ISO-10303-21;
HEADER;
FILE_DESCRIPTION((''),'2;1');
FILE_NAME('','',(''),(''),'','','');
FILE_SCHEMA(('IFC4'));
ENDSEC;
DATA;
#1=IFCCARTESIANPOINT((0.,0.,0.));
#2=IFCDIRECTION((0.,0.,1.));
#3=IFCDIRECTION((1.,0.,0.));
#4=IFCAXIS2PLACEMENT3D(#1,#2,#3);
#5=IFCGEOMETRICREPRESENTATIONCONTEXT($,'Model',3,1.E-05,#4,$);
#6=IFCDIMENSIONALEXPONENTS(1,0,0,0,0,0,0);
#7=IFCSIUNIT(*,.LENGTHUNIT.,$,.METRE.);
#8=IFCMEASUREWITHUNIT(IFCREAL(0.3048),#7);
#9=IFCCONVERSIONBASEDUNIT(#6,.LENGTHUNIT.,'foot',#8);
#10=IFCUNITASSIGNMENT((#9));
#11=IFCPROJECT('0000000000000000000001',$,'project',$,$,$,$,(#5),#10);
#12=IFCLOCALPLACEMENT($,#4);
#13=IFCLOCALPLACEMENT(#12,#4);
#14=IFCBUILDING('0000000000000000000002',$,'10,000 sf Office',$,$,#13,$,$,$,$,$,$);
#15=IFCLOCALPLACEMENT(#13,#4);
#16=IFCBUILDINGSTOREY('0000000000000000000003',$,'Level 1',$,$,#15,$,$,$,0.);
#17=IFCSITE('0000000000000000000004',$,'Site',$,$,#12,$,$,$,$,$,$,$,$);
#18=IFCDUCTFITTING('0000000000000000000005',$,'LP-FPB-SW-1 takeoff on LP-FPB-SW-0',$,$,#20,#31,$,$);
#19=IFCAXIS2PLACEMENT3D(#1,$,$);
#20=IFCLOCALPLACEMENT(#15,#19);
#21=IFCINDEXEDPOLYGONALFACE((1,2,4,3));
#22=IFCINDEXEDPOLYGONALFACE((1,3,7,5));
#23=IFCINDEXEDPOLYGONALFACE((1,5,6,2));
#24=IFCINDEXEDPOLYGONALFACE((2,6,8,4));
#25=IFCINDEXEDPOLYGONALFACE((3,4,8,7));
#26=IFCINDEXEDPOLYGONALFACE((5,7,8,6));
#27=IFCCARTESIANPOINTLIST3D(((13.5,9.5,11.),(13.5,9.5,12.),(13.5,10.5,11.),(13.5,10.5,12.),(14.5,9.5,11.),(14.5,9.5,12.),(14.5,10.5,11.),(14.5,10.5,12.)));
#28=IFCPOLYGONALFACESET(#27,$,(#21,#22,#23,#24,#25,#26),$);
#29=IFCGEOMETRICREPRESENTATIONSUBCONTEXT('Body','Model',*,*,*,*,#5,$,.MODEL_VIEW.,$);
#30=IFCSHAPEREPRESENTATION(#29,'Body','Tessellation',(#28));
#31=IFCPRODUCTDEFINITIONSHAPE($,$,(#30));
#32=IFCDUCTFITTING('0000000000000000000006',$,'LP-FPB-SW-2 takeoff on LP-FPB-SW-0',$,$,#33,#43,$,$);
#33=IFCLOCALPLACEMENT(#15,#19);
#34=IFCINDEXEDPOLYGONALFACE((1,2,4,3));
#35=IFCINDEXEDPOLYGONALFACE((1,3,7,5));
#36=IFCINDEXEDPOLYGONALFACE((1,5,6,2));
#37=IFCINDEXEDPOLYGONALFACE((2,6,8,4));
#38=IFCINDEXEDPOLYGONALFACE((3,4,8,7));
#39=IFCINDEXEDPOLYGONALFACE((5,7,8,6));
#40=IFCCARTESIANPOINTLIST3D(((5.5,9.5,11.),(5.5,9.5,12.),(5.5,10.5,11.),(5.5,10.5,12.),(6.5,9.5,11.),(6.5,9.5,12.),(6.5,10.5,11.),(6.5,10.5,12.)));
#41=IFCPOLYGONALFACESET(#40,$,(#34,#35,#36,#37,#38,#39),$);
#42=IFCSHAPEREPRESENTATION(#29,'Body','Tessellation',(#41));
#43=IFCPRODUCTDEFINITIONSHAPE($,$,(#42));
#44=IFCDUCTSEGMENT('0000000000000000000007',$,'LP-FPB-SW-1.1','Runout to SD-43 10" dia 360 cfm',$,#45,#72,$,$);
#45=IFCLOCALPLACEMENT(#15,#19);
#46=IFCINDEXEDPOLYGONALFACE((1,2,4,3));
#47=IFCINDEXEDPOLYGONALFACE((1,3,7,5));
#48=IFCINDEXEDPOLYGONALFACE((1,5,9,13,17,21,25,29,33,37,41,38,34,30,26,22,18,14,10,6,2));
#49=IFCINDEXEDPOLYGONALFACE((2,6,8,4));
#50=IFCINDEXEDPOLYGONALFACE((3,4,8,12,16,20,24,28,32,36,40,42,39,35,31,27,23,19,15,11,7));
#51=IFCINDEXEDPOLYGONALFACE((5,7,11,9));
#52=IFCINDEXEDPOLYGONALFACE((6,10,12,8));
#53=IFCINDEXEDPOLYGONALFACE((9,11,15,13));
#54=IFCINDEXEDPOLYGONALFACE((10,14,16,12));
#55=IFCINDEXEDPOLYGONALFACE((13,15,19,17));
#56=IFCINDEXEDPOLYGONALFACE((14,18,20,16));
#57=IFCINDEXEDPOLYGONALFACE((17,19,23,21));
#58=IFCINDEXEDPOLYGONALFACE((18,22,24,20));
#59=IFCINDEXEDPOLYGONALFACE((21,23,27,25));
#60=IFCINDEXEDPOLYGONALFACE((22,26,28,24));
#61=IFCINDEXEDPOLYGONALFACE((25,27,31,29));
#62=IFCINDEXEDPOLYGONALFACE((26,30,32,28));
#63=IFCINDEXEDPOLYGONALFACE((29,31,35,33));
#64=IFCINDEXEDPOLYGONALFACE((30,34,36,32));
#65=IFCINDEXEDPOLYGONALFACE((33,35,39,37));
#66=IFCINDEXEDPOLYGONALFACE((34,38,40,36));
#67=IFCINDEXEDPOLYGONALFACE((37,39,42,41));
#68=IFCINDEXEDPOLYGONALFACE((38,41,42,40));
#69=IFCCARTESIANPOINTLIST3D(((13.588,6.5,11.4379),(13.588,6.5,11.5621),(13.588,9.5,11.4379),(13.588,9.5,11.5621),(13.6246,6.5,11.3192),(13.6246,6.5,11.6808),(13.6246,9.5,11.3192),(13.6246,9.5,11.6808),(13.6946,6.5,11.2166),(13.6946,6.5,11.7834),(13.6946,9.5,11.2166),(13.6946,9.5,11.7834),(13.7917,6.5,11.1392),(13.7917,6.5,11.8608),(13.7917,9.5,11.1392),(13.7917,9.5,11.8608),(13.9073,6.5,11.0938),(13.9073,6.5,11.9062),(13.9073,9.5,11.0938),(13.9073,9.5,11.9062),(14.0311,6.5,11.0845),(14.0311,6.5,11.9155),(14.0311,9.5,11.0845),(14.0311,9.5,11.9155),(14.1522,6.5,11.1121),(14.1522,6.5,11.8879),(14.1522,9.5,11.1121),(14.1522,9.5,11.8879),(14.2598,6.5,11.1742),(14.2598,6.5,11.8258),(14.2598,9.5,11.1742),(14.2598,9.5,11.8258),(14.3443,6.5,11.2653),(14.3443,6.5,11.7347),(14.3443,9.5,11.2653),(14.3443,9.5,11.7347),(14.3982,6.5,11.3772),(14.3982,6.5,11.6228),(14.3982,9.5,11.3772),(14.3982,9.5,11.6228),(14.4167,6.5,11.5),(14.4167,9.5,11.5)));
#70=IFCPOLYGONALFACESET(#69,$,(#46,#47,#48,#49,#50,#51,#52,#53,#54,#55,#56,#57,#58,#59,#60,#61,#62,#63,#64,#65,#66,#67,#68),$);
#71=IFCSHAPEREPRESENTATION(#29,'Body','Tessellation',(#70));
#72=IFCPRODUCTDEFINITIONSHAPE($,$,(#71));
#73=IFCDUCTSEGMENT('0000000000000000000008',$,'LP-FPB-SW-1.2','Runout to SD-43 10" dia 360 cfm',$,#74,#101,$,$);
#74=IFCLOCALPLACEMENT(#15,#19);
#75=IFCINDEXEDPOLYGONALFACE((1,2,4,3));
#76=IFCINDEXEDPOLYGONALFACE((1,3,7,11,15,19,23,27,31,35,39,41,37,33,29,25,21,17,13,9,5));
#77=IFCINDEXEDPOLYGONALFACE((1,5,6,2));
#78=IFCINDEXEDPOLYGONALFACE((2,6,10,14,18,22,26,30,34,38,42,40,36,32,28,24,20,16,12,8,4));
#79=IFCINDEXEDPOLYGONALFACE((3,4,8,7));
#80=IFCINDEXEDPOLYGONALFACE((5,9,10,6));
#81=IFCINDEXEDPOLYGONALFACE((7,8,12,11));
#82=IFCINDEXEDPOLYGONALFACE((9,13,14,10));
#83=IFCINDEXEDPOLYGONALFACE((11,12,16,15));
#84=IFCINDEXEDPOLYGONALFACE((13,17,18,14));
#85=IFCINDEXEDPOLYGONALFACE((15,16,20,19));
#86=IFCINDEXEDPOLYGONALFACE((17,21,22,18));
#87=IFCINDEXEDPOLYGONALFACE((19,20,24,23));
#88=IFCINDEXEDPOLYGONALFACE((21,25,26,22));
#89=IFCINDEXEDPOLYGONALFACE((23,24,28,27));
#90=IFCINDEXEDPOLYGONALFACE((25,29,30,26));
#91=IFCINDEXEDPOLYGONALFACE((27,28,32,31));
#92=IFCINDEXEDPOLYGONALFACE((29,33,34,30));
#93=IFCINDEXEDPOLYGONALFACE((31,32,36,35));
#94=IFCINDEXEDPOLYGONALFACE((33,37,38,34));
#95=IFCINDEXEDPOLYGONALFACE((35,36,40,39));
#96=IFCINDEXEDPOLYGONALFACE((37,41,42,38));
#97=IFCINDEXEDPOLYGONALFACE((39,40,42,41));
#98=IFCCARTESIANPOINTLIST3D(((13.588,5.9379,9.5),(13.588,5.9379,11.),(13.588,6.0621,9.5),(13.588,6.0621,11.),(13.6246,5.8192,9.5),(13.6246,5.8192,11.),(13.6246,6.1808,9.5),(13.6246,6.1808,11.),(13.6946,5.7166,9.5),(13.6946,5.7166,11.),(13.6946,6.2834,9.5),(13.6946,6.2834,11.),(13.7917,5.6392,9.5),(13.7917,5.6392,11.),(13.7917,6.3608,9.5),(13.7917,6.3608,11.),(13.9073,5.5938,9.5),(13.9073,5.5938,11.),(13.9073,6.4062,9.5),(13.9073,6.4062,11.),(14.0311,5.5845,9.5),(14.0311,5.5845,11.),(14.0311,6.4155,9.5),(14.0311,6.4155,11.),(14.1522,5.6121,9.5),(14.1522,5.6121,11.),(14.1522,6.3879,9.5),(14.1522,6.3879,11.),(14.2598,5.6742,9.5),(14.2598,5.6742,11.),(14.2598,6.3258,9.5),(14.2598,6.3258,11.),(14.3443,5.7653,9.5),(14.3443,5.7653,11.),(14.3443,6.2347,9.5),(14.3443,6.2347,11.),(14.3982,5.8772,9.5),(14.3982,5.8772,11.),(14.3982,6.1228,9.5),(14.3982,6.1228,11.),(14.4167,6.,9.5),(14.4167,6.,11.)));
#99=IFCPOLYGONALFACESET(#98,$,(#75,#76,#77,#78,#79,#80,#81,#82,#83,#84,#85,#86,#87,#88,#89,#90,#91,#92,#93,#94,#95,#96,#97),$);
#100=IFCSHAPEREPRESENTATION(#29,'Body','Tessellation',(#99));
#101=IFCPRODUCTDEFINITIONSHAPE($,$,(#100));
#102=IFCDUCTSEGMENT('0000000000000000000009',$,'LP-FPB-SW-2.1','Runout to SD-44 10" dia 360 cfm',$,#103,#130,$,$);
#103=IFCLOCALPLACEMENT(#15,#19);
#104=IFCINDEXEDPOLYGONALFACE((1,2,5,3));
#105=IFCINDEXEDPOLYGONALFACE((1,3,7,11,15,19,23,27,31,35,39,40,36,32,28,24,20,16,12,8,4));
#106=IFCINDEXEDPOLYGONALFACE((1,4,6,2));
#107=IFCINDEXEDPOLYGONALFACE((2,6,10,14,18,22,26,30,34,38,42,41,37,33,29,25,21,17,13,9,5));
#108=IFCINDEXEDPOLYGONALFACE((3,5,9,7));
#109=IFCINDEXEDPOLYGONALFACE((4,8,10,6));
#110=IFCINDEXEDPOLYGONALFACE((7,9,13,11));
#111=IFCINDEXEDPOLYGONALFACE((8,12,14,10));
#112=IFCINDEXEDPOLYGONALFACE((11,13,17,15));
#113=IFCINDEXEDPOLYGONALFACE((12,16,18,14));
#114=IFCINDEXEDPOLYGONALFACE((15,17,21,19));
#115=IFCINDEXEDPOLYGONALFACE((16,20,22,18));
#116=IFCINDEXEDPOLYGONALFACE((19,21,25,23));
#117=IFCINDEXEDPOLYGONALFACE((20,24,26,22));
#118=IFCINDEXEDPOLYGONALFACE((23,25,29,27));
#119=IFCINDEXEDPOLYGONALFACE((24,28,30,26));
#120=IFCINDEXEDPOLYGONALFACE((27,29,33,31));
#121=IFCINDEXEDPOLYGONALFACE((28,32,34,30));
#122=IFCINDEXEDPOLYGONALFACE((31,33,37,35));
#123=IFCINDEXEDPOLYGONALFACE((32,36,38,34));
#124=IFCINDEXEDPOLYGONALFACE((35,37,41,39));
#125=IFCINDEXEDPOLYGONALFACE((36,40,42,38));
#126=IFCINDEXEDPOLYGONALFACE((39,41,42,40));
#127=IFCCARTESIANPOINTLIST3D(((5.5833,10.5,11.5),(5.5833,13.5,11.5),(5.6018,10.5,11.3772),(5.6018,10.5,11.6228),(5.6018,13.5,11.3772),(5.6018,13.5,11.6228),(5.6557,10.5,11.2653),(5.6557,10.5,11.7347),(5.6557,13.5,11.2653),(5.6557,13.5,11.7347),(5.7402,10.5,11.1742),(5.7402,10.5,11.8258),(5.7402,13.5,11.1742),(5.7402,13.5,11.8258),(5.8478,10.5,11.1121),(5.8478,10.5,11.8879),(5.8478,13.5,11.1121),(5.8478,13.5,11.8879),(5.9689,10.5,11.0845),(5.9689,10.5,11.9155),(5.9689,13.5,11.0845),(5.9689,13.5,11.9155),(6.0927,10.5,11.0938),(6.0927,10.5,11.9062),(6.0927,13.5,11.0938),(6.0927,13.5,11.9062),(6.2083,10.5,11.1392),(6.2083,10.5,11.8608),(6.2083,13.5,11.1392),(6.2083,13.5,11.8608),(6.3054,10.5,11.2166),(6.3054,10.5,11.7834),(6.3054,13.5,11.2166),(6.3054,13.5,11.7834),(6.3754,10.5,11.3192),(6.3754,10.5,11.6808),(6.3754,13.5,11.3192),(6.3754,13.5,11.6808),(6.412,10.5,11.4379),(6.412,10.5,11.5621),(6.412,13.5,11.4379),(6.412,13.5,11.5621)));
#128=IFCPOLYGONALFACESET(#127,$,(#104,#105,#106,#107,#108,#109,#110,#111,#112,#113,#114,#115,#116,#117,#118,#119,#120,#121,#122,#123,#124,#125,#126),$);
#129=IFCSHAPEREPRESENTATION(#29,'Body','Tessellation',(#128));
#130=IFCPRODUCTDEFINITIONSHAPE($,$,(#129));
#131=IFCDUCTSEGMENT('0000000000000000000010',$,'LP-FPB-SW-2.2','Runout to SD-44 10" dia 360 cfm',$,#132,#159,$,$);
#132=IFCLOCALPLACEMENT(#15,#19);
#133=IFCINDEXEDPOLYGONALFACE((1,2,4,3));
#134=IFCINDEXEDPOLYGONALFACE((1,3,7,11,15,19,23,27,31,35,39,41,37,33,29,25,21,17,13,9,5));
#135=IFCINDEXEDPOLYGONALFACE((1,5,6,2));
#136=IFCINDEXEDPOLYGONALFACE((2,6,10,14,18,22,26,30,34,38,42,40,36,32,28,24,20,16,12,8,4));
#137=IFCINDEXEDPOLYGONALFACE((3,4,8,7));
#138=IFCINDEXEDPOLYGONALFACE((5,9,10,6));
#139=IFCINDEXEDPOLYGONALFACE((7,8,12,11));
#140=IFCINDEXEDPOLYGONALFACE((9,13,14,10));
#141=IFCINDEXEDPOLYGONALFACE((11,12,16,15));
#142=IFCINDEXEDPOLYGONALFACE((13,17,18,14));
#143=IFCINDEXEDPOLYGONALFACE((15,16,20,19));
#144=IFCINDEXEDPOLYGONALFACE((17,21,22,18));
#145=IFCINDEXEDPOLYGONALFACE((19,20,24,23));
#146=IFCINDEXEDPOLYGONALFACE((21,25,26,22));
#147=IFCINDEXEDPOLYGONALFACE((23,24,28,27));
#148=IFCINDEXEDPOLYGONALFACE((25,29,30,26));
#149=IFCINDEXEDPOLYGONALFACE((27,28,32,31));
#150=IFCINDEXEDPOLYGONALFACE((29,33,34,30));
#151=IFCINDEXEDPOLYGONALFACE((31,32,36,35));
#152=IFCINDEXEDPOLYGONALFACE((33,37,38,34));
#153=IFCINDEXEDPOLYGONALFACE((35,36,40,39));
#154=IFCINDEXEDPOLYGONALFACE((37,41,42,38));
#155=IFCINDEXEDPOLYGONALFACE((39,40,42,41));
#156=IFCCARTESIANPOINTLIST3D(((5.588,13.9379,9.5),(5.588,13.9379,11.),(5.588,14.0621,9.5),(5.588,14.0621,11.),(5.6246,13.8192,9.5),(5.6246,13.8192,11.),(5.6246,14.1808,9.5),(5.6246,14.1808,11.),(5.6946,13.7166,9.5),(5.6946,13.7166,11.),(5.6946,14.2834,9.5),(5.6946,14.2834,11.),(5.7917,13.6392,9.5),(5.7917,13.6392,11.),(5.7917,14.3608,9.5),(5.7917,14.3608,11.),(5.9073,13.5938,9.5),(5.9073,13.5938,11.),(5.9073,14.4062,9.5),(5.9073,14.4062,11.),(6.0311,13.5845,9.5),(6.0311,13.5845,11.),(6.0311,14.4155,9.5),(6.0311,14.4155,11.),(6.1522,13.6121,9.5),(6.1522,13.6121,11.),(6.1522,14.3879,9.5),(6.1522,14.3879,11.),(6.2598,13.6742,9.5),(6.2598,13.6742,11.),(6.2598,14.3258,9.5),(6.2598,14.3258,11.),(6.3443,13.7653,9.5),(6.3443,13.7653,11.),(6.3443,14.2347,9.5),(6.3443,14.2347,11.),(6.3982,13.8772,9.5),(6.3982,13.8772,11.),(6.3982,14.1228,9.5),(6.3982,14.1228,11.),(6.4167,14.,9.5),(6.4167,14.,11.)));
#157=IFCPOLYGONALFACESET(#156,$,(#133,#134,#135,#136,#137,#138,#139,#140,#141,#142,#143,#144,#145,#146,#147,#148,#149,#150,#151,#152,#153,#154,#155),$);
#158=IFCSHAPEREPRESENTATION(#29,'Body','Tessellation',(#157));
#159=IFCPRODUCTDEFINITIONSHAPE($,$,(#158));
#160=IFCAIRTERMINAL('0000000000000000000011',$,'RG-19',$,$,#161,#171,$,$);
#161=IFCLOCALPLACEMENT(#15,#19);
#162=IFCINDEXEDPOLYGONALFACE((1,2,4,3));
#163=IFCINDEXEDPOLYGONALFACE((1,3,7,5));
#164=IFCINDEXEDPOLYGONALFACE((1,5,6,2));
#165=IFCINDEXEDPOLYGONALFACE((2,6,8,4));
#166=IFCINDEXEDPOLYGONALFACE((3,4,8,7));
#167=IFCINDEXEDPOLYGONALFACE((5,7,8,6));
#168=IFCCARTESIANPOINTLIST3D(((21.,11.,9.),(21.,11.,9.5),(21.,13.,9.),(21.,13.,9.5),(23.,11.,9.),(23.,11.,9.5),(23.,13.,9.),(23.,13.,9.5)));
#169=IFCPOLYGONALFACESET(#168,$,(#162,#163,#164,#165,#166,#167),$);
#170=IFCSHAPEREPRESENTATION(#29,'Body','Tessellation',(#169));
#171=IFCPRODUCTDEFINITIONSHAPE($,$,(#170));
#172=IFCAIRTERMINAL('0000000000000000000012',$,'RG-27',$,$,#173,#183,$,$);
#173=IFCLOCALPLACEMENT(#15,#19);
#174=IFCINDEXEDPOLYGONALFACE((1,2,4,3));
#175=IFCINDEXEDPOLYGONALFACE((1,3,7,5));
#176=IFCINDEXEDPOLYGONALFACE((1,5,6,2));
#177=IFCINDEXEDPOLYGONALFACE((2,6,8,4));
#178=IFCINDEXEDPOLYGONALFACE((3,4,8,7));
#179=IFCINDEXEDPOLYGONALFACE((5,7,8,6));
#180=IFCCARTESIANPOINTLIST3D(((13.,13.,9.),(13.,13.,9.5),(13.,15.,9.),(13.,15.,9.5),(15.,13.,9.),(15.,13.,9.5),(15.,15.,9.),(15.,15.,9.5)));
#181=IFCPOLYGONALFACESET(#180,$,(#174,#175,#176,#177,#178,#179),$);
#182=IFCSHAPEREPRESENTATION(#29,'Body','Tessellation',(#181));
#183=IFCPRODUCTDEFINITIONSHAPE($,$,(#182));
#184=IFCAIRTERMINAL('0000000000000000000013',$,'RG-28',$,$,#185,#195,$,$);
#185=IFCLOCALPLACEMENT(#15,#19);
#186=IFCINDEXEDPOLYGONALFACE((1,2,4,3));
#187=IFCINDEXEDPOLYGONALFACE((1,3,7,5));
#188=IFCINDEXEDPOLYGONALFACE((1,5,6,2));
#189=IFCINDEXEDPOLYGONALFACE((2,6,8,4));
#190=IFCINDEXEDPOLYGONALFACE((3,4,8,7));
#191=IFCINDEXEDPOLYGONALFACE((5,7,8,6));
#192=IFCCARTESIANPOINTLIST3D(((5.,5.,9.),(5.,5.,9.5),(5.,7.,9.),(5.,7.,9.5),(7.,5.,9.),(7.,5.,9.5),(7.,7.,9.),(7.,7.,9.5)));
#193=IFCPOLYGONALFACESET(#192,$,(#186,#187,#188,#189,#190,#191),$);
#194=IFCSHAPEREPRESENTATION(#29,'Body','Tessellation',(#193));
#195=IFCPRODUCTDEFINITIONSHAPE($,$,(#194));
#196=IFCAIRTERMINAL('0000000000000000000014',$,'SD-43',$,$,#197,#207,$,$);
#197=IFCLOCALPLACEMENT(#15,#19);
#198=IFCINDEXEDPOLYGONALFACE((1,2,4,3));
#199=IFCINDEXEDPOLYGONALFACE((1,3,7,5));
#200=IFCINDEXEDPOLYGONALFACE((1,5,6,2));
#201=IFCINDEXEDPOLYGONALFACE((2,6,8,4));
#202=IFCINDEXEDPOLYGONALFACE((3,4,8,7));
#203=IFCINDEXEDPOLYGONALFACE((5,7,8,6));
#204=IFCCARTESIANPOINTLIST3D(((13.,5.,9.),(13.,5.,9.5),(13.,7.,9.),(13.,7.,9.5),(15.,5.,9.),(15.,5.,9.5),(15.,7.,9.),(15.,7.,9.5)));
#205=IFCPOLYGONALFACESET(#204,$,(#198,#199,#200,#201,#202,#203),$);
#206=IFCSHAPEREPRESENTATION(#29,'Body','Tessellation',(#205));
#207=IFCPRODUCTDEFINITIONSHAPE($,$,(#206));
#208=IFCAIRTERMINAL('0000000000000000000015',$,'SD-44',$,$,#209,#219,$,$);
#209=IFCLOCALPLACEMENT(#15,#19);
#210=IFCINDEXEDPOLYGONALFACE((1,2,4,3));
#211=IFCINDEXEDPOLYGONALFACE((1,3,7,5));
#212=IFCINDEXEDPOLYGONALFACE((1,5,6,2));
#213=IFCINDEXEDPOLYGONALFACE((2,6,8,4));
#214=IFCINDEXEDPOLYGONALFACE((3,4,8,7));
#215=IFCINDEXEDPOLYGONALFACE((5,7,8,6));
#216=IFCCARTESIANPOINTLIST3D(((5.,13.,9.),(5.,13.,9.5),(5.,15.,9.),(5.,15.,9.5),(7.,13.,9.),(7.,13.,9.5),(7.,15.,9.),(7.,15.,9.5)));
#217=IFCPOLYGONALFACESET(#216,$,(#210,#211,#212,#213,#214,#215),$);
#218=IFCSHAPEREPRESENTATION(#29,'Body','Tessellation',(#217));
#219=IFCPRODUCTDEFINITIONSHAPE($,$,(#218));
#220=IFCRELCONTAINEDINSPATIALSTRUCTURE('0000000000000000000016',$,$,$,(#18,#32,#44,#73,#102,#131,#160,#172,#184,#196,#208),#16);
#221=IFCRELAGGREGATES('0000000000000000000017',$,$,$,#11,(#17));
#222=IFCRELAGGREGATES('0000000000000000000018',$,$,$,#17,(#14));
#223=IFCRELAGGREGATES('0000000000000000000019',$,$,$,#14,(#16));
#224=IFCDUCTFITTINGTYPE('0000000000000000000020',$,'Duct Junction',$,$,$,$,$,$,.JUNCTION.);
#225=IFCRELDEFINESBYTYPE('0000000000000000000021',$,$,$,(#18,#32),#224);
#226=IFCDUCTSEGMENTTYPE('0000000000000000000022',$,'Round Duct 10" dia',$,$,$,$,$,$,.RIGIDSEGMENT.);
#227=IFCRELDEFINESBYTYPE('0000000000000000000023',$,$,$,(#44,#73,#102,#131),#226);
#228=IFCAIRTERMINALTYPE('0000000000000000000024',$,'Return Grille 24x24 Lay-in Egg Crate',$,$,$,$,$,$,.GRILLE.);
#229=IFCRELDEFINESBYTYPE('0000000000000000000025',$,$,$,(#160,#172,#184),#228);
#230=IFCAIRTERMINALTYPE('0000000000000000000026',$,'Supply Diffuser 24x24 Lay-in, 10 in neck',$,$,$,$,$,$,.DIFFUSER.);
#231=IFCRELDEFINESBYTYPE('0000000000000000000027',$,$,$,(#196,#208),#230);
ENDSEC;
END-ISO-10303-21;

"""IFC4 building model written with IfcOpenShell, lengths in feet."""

from ifc_helpers import new_model, entity, si_unit, converted_unit, frame, origin_with_axes, place, context, subcontext, project, spatial, rectangle, circle, extrude, type_object, element, save


model = new_model("IFC4")

# Units and contexts
model_context = context("Model", 3, precision=1e-05, world=origin_with_axes())
body_context = subcontext(model_context, "Body", "Model", "MODEL_VIEW")
ifc_project = project(units=[converted_unit("LENGTHUNIT", "foot", entity("IfcReal", 0.3048), si_unit("LENGTHUNIT", "METRE"), dimensions=[1, 0, 0, 0, 0, 0, 0])], contexts=[model_context])

# Site, building, storey
site_placement = place(None, origin_with_axes())
site = spatial("IfcSite", under=ifc_project, at=site_placement, Name="Site")
building_placement = place(site_placement, origin_with_axes())
building = spatial("IfcBuilding", under=site, at=building_placement, Name="10,000 sf Office")
storey_placement = place(building_placement, origin_with_axes())
storey = spatial("IfcBuildingStorey", under=building, at=storey_placement, Name="Level 1", Elevation=0.0)

# Duct fittings
duct_fitting_type_1 = type_object("IfcDuctFittingType", Name="Duct Junction", PredefinedType="JUNCTION")
for number, where, z_axis, x_axis, name in (
    (1, (14.0, 10.0, 11.0), (0.0, 0.0, 1.0), (1.0, 0.0, 0.0), "LP-FPB-SW-1 takeoff on LP-FPB-SW-0"),
    (2, (6.0, 10.0, 11.0), (0.0, 0.0, 1.0), (1.0, 0.0, 0.0), "LP-FPB-SW-2 takeoff on LP-FPB-SW-0"),
):
    element("IfcDuctFitting", number, at=place(storey_placement, frame(where, z_axis=z_axis, x_axis=x_axis)), inside=storey, type_object=duct_fitting_type_1, Name=name, context=body_context, shape_type="SweptSolid", body=[
        extrude(rectangle(XDim=1.0, YDim=1.0), None, (0.0, 0.0, 1.0), 1.0),
    ])

# Duct segments
duct_segment_type_1 = type_object("IfcDuctSegmentType", Name="Round Duct 10\" dia", PredefinedType="RIGIDSEGMENT")
duct_segment_1_placement = place(storey_placement, frame((14.0, 9.5, 11.5), z_axis=(0.0, -1.0, 0.0), x_axis=(1.0, 0.0, 0.0)))
element("IfcDuctSegment", 3, at=duct_segment_1_placement, inside=storey, type_object=duct_segment_type_1, Name="LP-FPB-SW-1.1", Description="Runout to SD-43 10\" dia 360 cfm", context=body_context, shape_type="SweptSolid", body=[
    extrude(circle(Radius=0.4167), None, (0.0, 0.0, 1.0), 3.0),
])
duct_segment_2_placement = place(storey_placement, frame((14.0, 6.0, 11.0), z_axis=(0.0, 0.0, -1.0), x_axis=(1.0, 0.0, 0.0)))
element("IfcDuctSegment", 4, at=duct_segment_2_placement, inside=storey, type_object=duct_segment_type_1, Name="LP-FPB-SW-1.2", Description="Runout to SD-43 10\" dia 360 cfm", context=body_context, shape_type="SweptSolid", body=[
    extrude(circle(Radius=0.4167), None, (0.0, 0.0, 1.0), 1.5),
])
duct_segment_3_placement = place(storey_placement, frame((6.0, 10.5, 11.5), z_axis=(0.0, 1.0, 0.0), x_axis=(-1.0, 0.0, 0.0)))
element("IfcDuctSegment", 5, at=duct_segment_3_placement, inside=storey, type_object=duct_segment_type_1, Name="LP-FPB-SW-2.1", Description="Runout to SD-44 10\" dia 360 cfm", context=body_context, shape_type="SweptSolid", body=[
    extrude(circle(Radius=0.4167), None, (0.0, 0.0, 1.0), 3.0),
])
duct_segment_4_placement = place(storey_placement, frame((6.0, 14.0, 11.0), z_axis=(0.0, 0.0, -1.0), x_axis=(1.0, 0.0, 0.0)))
element("IfcDuctSegment", 6, at=duct_segment_4_placement, inside=storey, type_object=duct_segment_type_1, Name="LP-FPB-SW-2.2", Description="Runout to SD-44 10\" dia 360 cfm", context=body_context, shape_type="SweptSolid", body=[
    extrude(circle(Radius=0.4167), None, (0.0, 0.0, 1.0), 1.5),
])

# Air terminals
air_terminal_type_1 = type_object("IfcAirTerminalType", Name="Return Grille 24x24 Lay-in Egg Crate", PredefinedType="GRILLE")
for number, where, z_axis, x_axis, name in (
    (7, (22.0, 12.0, 9.0), (0.0, 0.0, 1.0), (1.0, 0.0, 0.0), "RG-19"),
    (8, (14.0, 14.0, 9.0), (0.0, 0.0, 1.0), (1.0, 0.0, 0.0), "RG-27"),
    (9, (6.0, 6.0, 9.0), (0.0, 0.0, 1.0), (1.0, 0.0, 0.0), "RG-28"),
):
    element("IfcAirTerminal", number, at=place(storey_placement, frame(where, z_axis=z_axis, x_axis=x_axis)), inside=storey, type_object=air_terminal_type_1, Name=name, context=body_context, shape_type="SweptSolid", body=[
        extrude(rectangle(XDim=2.0, YDim=2.0), None, (0.0, 0.0, 1.0), 0.5),
    ])
air_terminal_type_2 = type_object("IfcAirTerminalType", Name="Supply Diffuser 24x24 Lay-in, 10 in neck", PredefinedType="DIFFUSER")
for number, where, z_axis, x_axis, name in (
    (10, (14.0, 6.0, 9.0), (0.0, 0.0, 1.0), (1.0, 0.0, 0.0), "SD-43"),
    (11, (6.0, 14.0, 9.0), (0.0, 0.0, 1.0), (1.0, 0.0, 0.0), "SD-44"),
):
    element("IfcAirTerminal", number, at=place(storey_placement, frame(where, z_axis=z_axis, x_axis=x_axis)), inside=storey, type_object=air_terminal_type_2, Name=name, context=body_context, shape_type="SweptSolid", body=[
        extrude(rectangle(XDim=2.0, YDim=2.0), None, (0.0, 0.0, 1.0), 0.5),
    ])

save(model, "model.ifc")
